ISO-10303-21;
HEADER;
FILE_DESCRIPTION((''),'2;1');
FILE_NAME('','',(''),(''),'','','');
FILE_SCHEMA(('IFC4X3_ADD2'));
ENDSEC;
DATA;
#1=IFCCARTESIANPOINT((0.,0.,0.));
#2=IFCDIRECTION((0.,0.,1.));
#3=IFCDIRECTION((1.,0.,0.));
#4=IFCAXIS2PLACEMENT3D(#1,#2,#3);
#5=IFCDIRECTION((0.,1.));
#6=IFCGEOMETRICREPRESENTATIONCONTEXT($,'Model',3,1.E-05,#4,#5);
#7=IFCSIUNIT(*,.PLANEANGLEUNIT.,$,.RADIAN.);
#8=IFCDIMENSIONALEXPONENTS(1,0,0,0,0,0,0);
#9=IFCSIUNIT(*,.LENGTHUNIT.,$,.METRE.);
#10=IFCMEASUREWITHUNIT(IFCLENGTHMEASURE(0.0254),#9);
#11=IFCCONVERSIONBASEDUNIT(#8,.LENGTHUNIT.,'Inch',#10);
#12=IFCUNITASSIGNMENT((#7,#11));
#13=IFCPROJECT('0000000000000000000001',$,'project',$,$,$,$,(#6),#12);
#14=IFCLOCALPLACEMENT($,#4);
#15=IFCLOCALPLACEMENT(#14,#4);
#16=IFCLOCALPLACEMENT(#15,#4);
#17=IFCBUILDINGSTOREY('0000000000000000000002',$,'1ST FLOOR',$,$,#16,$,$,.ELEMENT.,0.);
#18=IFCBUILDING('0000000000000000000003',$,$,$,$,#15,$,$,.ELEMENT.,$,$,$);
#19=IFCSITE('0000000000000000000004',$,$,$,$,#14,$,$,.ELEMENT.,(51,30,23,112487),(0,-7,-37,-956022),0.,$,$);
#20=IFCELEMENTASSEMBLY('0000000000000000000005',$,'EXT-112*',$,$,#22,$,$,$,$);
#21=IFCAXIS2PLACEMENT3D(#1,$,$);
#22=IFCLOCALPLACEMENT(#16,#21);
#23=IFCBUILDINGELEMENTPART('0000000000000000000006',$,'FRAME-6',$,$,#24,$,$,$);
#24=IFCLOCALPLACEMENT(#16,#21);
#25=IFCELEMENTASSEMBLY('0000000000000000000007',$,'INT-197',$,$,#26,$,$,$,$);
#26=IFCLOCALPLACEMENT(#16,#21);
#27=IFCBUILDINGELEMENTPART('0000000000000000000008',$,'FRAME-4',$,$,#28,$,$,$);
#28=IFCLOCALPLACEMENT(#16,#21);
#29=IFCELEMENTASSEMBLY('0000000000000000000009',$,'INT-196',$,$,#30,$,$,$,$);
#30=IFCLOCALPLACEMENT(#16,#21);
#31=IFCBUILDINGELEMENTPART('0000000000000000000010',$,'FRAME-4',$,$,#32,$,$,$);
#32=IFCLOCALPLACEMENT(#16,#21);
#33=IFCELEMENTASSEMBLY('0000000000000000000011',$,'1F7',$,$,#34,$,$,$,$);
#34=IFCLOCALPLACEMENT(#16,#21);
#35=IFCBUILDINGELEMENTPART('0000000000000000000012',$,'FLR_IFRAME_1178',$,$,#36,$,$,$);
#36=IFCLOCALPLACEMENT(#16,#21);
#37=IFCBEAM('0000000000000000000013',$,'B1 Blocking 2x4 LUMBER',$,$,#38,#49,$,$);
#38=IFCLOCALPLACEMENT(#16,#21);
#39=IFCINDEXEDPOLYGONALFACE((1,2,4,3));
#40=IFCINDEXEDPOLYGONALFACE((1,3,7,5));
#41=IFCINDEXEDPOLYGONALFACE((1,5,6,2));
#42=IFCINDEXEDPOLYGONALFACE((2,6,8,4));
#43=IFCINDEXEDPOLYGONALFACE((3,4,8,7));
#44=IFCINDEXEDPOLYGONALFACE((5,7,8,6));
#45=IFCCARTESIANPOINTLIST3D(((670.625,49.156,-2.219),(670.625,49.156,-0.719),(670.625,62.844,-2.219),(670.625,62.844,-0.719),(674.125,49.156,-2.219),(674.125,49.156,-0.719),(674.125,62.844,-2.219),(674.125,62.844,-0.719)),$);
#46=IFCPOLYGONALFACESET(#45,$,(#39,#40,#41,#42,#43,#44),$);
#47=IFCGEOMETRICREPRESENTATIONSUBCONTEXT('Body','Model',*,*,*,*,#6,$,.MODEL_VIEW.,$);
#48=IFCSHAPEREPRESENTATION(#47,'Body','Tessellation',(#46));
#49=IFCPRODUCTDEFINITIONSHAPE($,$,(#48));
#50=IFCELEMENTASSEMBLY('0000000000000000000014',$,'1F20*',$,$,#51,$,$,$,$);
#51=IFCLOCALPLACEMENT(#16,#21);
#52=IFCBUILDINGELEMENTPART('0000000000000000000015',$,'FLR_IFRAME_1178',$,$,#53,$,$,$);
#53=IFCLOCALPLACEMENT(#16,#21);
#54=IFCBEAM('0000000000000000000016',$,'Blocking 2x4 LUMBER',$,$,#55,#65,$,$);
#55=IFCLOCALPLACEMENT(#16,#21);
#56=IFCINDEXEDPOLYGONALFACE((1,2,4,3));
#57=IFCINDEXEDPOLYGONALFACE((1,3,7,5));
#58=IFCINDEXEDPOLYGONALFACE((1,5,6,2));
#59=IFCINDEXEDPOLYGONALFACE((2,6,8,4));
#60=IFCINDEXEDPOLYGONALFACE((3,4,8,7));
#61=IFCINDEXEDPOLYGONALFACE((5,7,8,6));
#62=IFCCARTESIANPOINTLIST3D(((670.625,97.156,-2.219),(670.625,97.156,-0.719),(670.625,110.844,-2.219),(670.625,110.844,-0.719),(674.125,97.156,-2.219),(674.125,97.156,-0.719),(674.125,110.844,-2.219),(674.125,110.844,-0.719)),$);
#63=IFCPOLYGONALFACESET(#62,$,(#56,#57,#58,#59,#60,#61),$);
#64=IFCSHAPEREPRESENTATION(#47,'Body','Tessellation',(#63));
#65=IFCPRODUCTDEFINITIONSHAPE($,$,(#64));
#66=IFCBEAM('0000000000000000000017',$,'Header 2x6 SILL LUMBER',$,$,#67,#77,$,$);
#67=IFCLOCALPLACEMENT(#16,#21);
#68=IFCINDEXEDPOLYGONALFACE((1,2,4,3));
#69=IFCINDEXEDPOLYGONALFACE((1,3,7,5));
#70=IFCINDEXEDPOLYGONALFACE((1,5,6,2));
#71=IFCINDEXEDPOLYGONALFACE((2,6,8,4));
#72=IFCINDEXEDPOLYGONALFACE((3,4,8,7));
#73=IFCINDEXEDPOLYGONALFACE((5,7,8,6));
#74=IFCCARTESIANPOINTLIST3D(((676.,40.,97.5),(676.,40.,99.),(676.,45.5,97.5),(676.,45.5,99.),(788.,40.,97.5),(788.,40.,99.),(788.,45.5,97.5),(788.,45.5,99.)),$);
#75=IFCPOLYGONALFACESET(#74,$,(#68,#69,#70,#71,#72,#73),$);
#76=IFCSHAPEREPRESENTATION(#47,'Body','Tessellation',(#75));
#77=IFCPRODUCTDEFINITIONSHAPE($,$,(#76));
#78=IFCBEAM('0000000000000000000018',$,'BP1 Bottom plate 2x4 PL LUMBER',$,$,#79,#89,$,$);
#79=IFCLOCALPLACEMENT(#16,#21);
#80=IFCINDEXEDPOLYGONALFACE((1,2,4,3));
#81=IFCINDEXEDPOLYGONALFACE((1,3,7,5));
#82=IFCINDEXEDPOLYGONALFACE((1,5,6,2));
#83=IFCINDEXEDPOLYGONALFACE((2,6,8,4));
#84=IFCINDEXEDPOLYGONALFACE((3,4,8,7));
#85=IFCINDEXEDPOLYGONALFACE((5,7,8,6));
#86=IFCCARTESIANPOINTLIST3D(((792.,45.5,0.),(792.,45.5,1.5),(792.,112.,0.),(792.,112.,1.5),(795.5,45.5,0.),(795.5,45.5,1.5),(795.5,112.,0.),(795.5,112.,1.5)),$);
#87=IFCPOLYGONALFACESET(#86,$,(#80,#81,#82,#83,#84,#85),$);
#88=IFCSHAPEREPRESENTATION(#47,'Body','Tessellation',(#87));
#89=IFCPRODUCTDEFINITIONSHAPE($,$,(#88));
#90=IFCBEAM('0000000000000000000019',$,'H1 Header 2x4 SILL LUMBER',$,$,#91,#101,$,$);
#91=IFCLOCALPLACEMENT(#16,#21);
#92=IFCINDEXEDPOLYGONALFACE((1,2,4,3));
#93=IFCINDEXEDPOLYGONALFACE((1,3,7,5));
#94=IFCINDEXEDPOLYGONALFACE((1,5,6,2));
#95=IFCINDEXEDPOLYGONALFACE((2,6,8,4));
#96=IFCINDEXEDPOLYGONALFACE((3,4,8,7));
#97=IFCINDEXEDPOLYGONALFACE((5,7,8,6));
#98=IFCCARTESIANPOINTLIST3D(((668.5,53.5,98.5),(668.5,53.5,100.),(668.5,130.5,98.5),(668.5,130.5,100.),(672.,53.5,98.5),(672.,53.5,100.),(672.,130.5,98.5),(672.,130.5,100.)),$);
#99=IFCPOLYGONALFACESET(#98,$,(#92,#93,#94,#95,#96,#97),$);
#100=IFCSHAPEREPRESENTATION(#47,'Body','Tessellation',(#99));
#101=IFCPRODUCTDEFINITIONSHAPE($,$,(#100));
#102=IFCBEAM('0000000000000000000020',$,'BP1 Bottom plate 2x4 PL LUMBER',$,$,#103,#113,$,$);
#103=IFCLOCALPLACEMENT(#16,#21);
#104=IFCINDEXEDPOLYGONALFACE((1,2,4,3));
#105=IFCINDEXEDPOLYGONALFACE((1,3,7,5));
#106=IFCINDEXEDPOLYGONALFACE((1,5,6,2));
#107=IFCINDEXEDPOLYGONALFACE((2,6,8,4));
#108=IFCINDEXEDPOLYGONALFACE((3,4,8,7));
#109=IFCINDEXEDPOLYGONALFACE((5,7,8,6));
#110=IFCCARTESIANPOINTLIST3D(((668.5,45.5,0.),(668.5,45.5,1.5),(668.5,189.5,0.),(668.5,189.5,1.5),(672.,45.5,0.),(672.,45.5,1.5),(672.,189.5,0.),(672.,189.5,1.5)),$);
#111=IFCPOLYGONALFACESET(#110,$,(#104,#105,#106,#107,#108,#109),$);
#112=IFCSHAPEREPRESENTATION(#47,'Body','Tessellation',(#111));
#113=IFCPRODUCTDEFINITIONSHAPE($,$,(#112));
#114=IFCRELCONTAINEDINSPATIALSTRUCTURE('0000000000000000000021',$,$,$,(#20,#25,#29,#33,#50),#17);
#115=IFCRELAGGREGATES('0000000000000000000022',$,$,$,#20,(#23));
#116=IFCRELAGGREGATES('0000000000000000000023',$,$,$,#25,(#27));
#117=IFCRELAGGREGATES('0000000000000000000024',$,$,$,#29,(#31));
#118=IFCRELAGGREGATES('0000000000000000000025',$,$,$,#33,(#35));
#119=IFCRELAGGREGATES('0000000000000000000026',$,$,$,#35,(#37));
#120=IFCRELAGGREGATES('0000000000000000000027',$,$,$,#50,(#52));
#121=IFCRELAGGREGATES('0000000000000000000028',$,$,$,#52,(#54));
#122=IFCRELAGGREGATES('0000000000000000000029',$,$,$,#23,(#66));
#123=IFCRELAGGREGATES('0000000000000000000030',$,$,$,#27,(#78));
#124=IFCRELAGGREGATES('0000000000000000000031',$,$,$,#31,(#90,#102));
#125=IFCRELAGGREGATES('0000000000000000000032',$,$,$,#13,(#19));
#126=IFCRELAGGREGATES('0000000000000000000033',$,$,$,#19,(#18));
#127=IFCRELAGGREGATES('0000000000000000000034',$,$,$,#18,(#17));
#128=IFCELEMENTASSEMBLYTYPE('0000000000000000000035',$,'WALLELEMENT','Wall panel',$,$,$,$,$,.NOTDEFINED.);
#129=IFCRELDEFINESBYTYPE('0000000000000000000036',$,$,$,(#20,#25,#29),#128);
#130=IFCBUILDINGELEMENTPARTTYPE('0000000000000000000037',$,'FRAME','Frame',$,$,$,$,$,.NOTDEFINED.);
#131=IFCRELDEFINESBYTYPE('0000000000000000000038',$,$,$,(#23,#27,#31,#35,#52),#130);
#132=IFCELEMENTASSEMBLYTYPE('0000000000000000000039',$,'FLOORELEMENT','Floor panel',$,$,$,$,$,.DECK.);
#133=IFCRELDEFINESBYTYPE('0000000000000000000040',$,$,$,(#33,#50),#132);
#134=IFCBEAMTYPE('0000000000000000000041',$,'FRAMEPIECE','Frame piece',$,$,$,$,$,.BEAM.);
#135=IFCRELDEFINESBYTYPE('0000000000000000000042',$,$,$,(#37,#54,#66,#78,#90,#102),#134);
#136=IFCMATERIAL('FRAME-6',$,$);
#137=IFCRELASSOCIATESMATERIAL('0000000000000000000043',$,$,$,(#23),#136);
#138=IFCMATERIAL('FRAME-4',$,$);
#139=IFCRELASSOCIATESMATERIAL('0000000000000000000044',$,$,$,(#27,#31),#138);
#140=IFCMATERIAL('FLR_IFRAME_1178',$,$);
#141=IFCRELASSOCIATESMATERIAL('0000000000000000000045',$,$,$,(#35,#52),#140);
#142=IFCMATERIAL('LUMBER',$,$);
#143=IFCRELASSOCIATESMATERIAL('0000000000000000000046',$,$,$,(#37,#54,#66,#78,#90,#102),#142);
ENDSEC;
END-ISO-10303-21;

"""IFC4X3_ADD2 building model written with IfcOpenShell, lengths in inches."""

from ifc_helpers import new_model, entity, si_unit, converted_unit, direction, frame, origin_with_axes, origin_2d_with_axis, place, context, subcontext, project, spatial, rectangle, extrude, material, type_object, element, aggregate, save


model = new_model("IFC4X3_ADD2")

# Units and contexts
model_context = context("Model", 3, precision=1e-05, world=origin_with_axes(), true_north=direction((0.0, 1.0)))
body_context = subcontext(model_context, "Body", "Model", "MODEL_VIEW")
ifc_project = project(units=[si_unit("PLANEANGLEUNIT", "RADIAN"), converted_unit("LENGTHUNIT", "Inch", entity("IfcLengthMeasure", 0.0254), si_unit("LENGTHUNIT", "METRE"), dimensions=[1, 0, 0, 0, 0, 0, 0])], contexts=[model_context])

# Site, building, storey
site_placement = place(None, origin_with_axes())
site = spatial("IfcSite", under=ifc_project, at=site_placement, CompositionType="ELEMENT", RefLatitude=(51, 30, 23, 112487), RefLongitude=(0, -7, -37, -956022), RefElevation=0.0)
building_placement = place(site_placement, origin_with_axes())
building = spatial("IfcBuilding", under=site, at=building_placement, CompositionType="ELEMENT")
storey_placement = place(building_placement, origin_with_axes())
storey = spatial("IfcBuildingStorey", under=building, at=storey_placement, Name="1ST FLOOR", CompositionType="ELEMENT", Elevation=0.0)

# Element assembly, building element part
element_assembly_type_1 = type_object("IfcElementAssemblyType", Name="WALLELEMENT", Description="Wall panel", PredefinedType="NOTDEFINED")
assembly_1_placement = place(storey_placement, origin_with_axes())
assembly_1 = element("IfcElementAssembly", 1, at=assembly_1_placement, inside=storey, type_object=element_assembly_type_1, Name="EXT-112*")
ifc_material_1 = material(Name="FRAME-6")
building_element_part_type = type_object("IfcBuildingElementPartType", Name="FRAME", Description="Frame", PredefinedType="NOTDEFINED")
building_element_part_1_placement = place(storey_placement, origin_with_axes())
building_element_part_1 = element("IfcBuildingElementPart", 2, at=building_element_part_1_placement, type_object=building_element_part_type, material=ifc_material_1, Name="FRAME-6")
aggregate(assembly_1, [building_element_part_1])
ifc_material_2 = material(Name="LUMBER")

# Element assemblies, building element parts
assembly_2_placement = place(storey_placement, origin_with_axes())
assembly_2 = element("IfcElementAssembly", 3, at=assembly_2_placement, inside=storey, type_object=element_assembly_type_1, Name="INT-197")
ifc_material_3 = material(Name="FRAME-4")
building_element_part_2_placement = place(storey_placement, origin_with_axes())
building_element_part_2 = element("IfcBuildingElementPart", 4, at=building_element_part_2_placement, type_object=building_element_part_type, material=ifc_material_3, Name="FRAME-4")
aggregate(assembly_2, [building_element_part_2])
assembly_3_placement = place(storey_placement, origin_with_axes())
assembly_3 = element("IfcElementAssembly", 5, at=assembly_3_placement, inside=storey, type_object=element_assembly_type_1, Name="INT-196")
building_element_part_3_placement = place(storey_placement, origin_with_axes())
building_element_part_3 = element("IfcBuildingElementPart", 6, at=building_element_part_3_placement, type_object=building_element_part_type, material=ifc_material_3, Name="FRAME-4")
aggregate(assembly_3, [building_element_part_3])

# Element assembly, building element part, beam
element_assembly_type_2 = type_object("IfcElementAssemblyType", Name="FLOORELEMENT", Description="Floor panel", PredefinedType="DECK")
assembly_4_placement = place(storey_placement, origin_with_axes())
assembly_4 = element("IfcElementAssembly", 7, at=assembly_4_placement, inside=storey, type_object=element_assembly_type_2, Name="1F7")
ifc_material_4 = material(Name="FLR_IFRAME_1178")
building_element_part_4_placement = place(storey_placement, origin_with_axes())
building_element_part_4 = element("IfcBuildingElementPart", 8, at=building_element_part_4_placement, type_object=building_element_part_type, material=ifc_material_4, Name="FLR_IFRAME_1178")
aggregate(assembly_4, [building_element_part_4])
beam_type = type_object("IfcBeamType", Name="FRAMEPIECE", Description="Frame piece", PredefinedType="BEAM")
beam_1_placement = place(storey_placement, frame((672.375, 62.844, -1.469), z_axis=(0.0, -1.0, 0.0), x_axis=(0.0, 0.0, 1.0)))
beam_1 = element("IfcBeam", 9, at=beam_1_placement, type_object=beam_type, material=ifc_material_2, Name="B1 Blocking 2x4 LUMBER", context=body_context, shape_type="SweptSolid", body=[
    extrude(rectangle(XDim=1.5, YDim=3.5, at=origin_2d_with_axis()), origin_with_axes(), (0.0, 0.0, 1.0), 13.687),
])
aggregate(building_element_part_4, [beam_1])

# Element assembly, building element part, beam
assembly_5_placement = place(storey_placement, origin_with_axes())
assembly_5 = element("IfcElementAssembly", 10, at=assembly_5_placement, inside=storey, type_object=element_assembly_type_2, Name="1F20*")
building_element_part_5_placement = place(storey_placement, origin_with_axes())
building_element_part_5 = element("IfcBuildingElementPart", 11, at=building_element_part_5_placement, type_object=building_element_part_type, material=ifc_material_4, Name="FLR_IFRAME_1178")
aggregate(assembly_5, [building_element_part_5])
beam_2_placement = place(storey_placement, frame((672.375, 110.844, -1.469), z_axis=(0.0, -1.0, 0.0), x_axis=(0.0, 0.0, 1.0)))
beam_2 = element("IfcBeam", 12, at=beam_2_placement, type_object=beam_type, material=ifc_material_2, Name="Blocking 2x4 LUMBER", context=body_context, shape_type="SweptSolid", body=[
    extrude(rectangle(XDim=1.5, YDim=3.5, at=origin_2d_with_axis()), origin_with_axes(), (0.0, 0.0, 1.0), 13.687),
])
aggregate(building_element_part_5, [beam_2])

# Beams
beam_3_placement = place(storey_placement, frame((788.0, 42.75, 98.25), z_axis=(-1.0, 0.0, 0.0), x_axis=(0.0, 0.0, -1.0)))
beam_3 = element("IfcBeam", 13, at=beam_3_placement, type_object=beam_type, material=ifc_material_2, Name="Header 2x6 SILL LUMBER", context=body_context, shape_type="SweptSolid", body=[
    extrude(rectangle(XDim=1.5, YDim=5.5, at=origin_2d_with_axis()), origin_with_axes(), (0.0, 0.0, 1.0), 112.0),
])
aggregate(building_element_part_1, [beam_3])
beam_4_placement = place(storey_placement, frame((793.75, 112.0, 0.75), z_axis=(0.0, -1.0, 0.0), x_axis=(0.0, 0.0, 1.0)))
beam_4 = element("IfcBeam", 14, at=beam_4_placement, type_object=beam_type, material=ifc_material_2, Name="BP1 Bottom plate 2x4 PL LUMBER", context=body_context, shape_type="SweptSolid", body=[
    extrude(rectangle(XDim=1.5, YDim=3.5, at=origin_2d_with_axis()), origin_with_axes(), (0.0, 0.0, 1.0), 66.5),
])
aggregate(building_element_part_2, [beam_4])
beam_5_placement = place(storey_placement, frame((670.25, 53.5, 99.25), z_axis=(0.0, 1.0, 0.0), x_axis=(0.0, 0.0, 1.0)))
beam_5 = element("IfcBeam", 15, at=beam_5_placement, type_object=beam_type, material=ifc_material_2, Name="H1 Header 2x4 SILL LUMBER", context=body_context, shape_type="SweptSolid", body=[
    extrude(rectangle(XDim=1.5, YDim=3.5, at=origin_2d_with_axis()), origin_with_axes(), (0.0, 0.0, 1.0), 77.0),
])
beam_6_placement = place(storey_placement, frame((670.25, 45.5, 0.75), z_axis=(0.0, 1.0, 0.0), x_axis=(0.0, 0.0, 1.0)))
beam_6 = element("IfcBeam", 16, at=beam_6_placement, type_object=beam_type, material=ifc_material_2, Name="BP1 Bottom plate 2x4 PL LUMBER", context=body_context, shape_type="SweptSolid", body=[
    extrude(rectangle(XDim=1.5, YDim=3.5, at=origin_2d_with_axis()), origin_with_axes(), (0.0, 0.0, 1.0), 144.0),
])
aggregate(building_element_part_3, [beam_5, beam_6])

save(model, "model.ifc")
